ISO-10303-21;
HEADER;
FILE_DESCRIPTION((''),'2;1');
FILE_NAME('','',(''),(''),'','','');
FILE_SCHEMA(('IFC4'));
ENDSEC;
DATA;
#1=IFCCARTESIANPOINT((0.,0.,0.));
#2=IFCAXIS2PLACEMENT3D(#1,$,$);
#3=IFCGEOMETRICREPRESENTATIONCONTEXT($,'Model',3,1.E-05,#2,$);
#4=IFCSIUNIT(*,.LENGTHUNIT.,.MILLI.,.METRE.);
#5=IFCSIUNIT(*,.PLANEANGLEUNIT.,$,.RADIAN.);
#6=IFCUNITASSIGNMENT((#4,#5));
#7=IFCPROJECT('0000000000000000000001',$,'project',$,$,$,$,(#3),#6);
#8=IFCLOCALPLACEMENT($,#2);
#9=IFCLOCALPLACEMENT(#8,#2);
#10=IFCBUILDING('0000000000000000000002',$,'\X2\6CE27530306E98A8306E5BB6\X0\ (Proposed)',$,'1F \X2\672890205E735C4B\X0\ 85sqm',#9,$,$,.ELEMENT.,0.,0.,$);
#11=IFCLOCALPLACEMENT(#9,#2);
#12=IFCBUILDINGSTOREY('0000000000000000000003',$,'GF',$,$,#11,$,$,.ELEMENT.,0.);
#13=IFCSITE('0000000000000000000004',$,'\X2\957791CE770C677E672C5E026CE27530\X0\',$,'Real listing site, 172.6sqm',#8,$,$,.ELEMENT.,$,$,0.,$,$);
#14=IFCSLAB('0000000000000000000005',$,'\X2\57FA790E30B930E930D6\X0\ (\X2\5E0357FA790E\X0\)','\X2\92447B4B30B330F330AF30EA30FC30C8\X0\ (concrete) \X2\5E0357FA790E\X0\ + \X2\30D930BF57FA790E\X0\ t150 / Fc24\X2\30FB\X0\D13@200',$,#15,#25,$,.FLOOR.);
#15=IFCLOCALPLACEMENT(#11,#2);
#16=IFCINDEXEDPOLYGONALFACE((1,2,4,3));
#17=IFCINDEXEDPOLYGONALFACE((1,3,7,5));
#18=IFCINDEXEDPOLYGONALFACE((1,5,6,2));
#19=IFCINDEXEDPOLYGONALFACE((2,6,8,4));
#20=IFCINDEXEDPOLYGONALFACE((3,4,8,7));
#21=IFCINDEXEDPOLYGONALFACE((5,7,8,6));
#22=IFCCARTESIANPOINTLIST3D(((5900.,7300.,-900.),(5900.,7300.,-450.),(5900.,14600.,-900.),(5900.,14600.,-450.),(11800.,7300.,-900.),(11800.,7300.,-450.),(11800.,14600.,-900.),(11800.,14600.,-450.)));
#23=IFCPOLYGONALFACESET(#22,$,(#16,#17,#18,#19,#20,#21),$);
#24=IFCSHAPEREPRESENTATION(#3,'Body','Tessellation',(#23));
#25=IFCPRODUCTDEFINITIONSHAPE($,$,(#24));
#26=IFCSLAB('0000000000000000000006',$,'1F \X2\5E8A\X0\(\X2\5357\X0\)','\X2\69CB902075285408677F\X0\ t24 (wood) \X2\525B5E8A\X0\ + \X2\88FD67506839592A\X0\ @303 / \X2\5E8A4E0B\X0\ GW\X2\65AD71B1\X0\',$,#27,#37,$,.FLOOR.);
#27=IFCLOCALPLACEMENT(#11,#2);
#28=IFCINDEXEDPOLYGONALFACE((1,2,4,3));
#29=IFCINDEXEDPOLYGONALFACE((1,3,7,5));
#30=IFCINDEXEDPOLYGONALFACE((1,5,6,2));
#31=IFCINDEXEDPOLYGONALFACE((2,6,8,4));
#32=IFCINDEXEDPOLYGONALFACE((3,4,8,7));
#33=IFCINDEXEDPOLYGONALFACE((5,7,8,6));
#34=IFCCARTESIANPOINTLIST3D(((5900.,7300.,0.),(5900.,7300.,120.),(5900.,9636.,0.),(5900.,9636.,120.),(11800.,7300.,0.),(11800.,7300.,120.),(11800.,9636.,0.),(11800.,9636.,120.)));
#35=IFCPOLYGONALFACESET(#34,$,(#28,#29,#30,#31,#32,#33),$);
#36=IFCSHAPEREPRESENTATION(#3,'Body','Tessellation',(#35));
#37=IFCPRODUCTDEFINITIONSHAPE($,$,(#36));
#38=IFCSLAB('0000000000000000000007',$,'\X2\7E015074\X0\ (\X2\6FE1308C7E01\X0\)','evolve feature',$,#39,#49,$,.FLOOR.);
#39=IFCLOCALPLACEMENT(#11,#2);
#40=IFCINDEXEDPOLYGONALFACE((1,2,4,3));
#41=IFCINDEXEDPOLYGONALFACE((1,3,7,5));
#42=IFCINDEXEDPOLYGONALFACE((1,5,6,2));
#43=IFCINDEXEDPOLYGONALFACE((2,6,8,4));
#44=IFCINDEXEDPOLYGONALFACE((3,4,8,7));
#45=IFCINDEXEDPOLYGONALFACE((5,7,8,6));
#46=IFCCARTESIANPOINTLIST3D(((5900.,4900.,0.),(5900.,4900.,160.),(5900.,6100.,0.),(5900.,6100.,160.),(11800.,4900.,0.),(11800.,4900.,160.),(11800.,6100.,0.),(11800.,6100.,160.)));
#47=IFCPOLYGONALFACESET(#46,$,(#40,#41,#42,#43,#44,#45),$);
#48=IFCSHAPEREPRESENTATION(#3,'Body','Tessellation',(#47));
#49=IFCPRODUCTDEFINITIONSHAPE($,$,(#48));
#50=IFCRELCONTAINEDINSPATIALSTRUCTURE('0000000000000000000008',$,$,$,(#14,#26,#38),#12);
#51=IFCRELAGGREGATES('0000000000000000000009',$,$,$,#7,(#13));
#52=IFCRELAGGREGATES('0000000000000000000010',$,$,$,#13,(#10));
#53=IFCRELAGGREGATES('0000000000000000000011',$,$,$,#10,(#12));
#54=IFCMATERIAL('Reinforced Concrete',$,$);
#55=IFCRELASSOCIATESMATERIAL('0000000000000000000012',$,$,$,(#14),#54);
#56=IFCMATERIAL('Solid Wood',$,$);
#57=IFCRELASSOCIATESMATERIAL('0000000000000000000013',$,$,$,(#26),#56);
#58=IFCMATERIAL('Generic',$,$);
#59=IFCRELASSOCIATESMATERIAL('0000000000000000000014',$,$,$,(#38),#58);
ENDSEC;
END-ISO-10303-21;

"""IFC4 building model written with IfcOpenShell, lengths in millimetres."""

from ifc_helpers import new_model, si_unit, frame, frame_2d, origin, place, context, project, spatial, rectangle, extrude, material, element, save


model = new_model("IFC4")

# Units and contexts
model_context = context("Model", 3, precision=1e-05, world=origin())
ifc_project = project(units=[si_unit("LENGTHUNIT", "METRE", prefix="MILLI"), si_unit("PLANEANGLEUNIT", "RADIAN")], contexts=[model_context])

# Site, building, storey
site_placement = place(None, origin())
site = spatial("IfcSite", under=ifc_project, at=site_placement, Name="長野県松本市波田", ObjectType="Real listing site, 172.6sqm", CompositionType="ELEMENT", RefElevation=0.0)
building_placement = place(site_placement, origin())
building = spatial("IfcBuilding", under=site, at=building_placement, Name="波田の風の家 (Proposed)", ObjectType="1F 木造平屋 85sqm", CompositionType="ELEMENT", ElevationOfRefHeight=0.0, ElevationOfTerrain=0.0)
storey_placement = place(building_placement, origin())
storey = spatial("IfcBuildingStorey", under=building, at=storey_placement, Name="GF", CompositionType="ELEMENT", Elevation=0.0)

# Slabs
ifc_material_1 = material(Name="Reinforced Concrete")
slab_1_placement = place(storey_placement, frame((2950.0, 3650.0, -450.0)))
element("IfcSlab", 1, at=slab_1_placement, inside=storey, material=ifc_material_1, Name="基礎スラブ (布基礎)", Description="鉄筋コンクリート (concrete) 布基礎 + ベタ基礎 t150 / Fc24・D13@200", PredefinedType="FLOOR", context=model_context, shape_type="SweptSolid", body=[
    extrude(rectangle(XDim=5900.0, YDim=7300.0, at=frame_2d((2950.0, 3650.0))), frame((2950.0, 3650.0, -450.0)), (0.0, 0.0, 1.0), 450.0),
])
ifc_material_2 = material(Name="Solid Wood")
slab_2_placement = place(storey_placement, frame((2950.0, 3650.0, 0.0)))
element("IfcSlab", 2, at=slab_2_placement, inside=storey, material=ifc_material_2, Name="1F 床(南)", Description="構造用合板 t24 (wood) 剛床 + 製材根太 @303 / 床下 GW断熱", PredefinedType="FLOOR", context=model_context, shape_type="SweptSolid", body=[
    extrude(rectangle(XDim=5900.0, YDim=2336.0, at=frame_2d((2950.0, 1168.0))), frame((2950.0, 3650.0, 0.0)), (0.0, 0.0, 1.0), 120.0),
])
ifc_material_3 = material(Name="Generic")
slab_3_placement = place(storey_placement, frame((2950.0, 2450.0, 0.0)))
element("IfcSlab", 3, at=slab_3_placement, inside=storey, material=ifc_material_3, Name="縁側 (濡れ縁)", Description="evolve feature", PredefinedType="FLOOR", context=model_context, shape_type="SweptSolid", body=[
    extrude(rectangle(XDim=5900.0, YDim=1200.0, at=frame_2d((2950.0, 600.0))), frame((2950.0, 2450.0, 0.0)), (0.0, 0.0, 1.0), 160.0),
])

save(model, "model.ifc")
